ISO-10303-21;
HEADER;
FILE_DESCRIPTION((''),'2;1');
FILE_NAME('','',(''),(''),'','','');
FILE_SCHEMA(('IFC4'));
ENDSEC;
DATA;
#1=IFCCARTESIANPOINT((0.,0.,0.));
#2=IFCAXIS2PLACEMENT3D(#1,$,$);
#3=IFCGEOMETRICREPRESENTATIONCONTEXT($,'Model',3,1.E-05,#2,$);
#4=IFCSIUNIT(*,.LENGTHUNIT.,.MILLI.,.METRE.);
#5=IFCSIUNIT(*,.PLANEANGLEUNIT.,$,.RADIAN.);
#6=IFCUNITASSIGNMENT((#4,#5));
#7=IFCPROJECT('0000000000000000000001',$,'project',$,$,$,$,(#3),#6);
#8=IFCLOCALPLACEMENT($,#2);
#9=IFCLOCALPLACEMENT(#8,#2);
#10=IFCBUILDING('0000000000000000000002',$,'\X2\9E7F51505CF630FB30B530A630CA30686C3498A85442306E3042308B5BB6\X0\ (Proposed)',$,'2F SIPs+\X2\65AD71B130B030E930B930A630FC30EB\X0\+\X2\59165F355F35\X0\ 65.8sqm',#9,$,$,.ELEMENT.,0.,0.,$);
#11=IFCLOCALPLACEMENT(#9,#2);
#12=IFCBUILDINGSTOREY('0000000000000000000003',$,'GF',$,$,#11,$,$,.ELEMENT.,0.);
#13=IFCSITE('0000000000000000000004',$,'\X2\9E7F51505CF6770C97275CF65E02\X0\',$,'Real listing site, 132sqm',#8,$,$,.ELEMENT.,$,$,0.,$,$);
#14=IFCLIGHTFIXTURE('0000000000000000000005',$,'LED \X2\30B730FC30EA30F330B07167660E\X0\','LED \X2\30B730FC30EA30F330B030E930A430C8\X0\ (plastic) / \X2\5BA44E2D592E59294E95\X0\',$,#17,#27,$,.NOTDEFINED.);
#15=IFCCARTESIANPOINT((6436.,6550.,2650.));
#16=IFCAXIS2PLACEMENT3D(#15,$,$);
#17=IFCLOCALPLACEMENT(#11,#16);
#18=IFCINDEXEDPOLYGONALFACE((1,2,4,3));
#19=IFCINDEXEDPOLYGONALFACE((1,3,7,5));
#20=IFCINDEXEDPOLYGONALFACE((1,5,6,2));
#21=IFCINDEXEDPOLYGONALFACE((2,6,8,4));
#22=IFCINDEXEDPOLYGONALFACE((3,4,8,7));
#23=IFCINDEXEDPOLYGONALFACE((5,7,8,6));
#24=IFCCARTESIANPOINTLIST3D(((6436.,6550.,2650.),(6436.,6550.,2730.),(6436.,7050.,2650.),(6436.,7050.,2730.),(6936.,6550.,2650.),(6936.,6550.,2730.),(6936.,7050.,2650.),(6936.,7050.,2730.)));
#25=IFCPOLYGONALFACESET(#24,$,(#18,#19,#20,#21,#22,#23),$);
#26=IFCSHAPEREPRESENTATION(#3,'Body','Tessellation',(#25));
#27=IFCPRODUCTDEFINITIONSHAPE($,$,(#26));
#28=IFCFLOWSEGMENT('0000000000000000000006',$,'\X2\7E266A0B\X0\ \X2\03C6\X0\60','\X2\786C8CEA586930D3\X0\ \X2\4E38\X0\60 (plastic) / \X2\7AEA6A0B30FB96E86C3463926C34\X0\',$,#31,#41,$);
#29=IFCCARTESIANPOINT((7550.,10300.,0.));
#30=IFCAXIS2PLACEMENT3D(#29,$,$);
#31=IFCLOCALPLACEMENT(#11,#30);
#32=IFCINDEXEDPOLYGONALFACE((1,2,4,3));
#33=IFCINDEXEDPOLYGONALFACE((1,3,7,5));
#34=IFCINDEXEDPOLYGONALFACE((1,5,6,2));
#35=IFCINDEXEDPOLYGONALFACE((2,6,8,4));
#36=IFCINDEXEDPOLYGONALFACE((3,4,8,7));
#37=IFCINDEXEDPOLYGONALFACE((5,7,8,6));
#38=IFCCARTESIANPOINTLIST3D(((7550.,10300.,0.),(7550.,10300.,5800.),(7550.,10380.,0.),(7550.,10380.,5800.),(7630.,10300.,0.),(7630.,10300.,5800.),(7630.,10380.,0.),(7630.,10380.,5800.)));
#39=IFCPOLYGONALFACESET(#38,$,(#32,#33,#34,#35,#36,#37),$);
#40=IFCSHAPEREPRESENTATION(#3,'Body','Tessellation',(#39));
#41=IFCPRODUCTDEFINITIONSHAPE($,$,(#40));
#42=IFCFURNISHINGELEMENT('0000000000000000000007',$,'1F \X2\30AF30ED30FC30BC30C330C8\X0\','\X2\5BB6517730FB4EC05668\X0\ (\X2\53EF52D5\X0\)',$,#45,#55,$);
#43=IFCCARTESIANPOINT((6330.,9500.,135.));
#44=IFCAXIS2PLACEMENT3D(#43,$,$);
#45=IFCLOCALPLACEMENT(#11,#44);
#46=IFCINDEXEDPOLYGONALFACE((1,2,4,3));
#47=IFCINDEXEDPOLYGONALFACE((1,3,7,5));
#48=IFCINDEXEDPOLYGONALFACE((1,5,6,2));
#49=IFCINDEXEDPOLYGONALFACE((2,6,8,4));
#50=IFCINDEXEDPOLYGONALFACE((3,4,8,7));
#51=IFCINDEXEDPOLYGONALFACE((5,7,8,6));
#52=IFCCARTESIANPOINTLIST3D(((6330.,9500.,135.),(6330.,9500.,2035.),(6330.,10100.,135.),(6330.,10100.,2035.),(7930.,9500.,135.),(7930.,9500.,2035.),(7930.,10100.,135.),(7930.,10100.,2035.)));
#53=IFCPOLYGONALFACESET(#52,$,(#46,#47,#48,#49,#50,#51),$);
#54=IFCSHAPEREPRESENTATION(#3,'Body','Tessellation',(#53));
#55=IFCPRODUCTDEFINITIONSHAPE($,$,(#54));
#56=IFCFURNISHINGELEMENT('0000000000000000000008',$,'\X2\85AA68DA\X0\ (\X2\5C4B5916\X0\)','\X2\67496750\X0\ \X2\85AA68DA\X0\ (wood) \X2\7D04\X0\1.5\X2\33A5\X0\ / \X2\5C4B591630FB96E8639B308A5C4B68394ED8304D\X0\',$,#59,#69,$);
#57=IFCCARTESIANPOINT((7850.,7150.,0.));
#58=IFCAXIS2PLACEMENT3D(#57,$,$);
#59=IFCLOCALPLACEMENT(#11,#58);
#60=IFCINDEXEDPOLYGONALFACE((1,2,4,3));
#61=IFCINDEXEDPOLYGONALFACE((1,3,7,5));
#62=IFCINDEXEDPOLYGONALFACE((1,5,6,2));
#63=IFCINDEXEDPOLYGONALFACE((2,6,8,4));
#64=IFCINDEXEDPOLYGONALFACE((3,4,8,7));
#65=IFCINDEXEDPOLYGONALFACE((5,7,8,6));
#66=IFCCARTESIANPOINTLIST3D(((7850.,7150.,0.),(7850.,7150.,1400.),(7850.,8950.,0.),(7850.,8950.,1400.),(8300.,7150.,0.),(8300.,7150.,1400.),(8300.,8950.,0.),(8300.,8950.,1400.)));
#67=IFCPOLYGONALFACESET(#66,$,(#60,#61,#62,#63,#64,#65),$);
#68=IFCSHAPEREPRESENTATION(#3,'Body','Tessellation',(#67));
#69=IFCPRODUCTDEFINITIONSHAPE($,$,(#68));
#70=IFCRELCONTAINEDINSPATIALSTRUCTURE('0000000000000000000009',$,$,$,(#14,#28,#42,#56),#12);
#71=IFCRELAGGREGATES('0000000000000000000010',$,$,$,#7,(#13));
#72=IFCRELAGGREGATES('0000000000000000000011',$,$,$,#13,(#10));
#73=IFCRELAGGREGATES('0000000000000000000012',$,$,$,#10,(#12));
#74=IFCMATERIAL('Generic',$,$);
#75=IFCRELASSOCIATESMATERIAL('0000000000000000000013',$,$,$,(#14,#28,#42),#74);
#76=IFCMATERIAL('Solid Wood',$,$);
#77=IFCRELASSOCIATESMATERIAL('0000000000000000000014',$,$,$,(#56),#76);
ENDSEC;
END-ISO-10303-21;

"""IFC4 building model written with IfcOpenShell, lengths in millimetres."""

from ifc_helpers import new_model, si_unit, frame, frame_2d, origin, place, context, project, spatial, rectangle, extrude, material, element, save


model = new_model("IFC4")

# Units and contexts
model_context = context("Model", 3, precision=1e-05, world=origin())
ifc_project = project(units=[si_unit("LENGTHUNIT", "METRE", prefix="MILLI"), si_unit("PLANEANGLEUNIT", "RADIAN")], contexts=[model_context])

# Site, building, storey
site_placement = place(None, origin())
site = spatial("IfcSite", under=ifc_project, at=site_placement, Name="鹿児島県霧島市", ObjectType="Real listing site, 132sqm", CompositionType="ELEMENT", RefElevation=0.0)
building_placement = place(site_placement, origin())
building = spatial("IfcBuilding", under=site, at=building_placement, Name="鹿児島・サウナと水風呂のある家 (Proposed)", ObjectType="2F SIPs+断熱グラスウール+外張張 65.8sqm", CompositionType="ELEMENT", ElevationOfRefHeight=0.0, ElevationOfTerrain=0.0)
storey_placement = place(building_placement, origin())
storey = spatial("IfcBuildingStorey", under=building, at=storey_placement, Name="GF", CompositionType="ELEMENT", Elevation=0.0)

# Shared definitions
ifc_material_1 = material(Name="Solid Wood")

# Shared definitions
ifc_material_2 = material(Name="Generic")

# Light fixture
light_fixture_placement = place(storey_placement, frame((6436.0, 6550.0, 2650.0)))
element("IfcLightFixture", 1, at=light_fixture_placement, inside=storey, material=ifc_material_2, Name="LED シーリング照明", Description="LED シーリングライト (plastic) / 室中央天井", PredefinedType="NOTDEFINED", context=model_context, shape_type="SweptSolid", body=[
    extrude(rectangle(XDim=500.0, YDim=500.0, at=frame_2d((250.0, 250.0))), frame((6436.0, 6550.0, 2650.0)), (0.0, 0.0, 1.0), 80.0),
])

# Flow segment
flow_segment_placement = place(storey_placement, frame((7550.0, 10300.0, 0.0)))
element("IfcFlowSegment", 2, at=flow_segment_placement, inside=storey, material=ifc_material_2, Name="縦樋 φ60", Description="硬質塩ビ 丸60 (plastic) / 竪樋・雨水排水", context=model_context, shape_type="SweptSolid", body=[
    extrude(rectangle(XDim=80.0, YDim=80.0, at=frame_2d((40.0, 40.0))), frame((7550.0, 10300.0, 0.0)), (0.0, 0.0, 1.0), 5800.0),
])

# Furnishing elements
furnishing_1_placement = place(storey_placement, frame((6330.0, 9500.0, 135.0)))
element("IfcFurnishingElement", 3, at=furnishing_1_placement, inside=storey, material=ifc_material_2, Name="1F クローゼット", Description="家具・什器 (可動)", context=model_context, shape_type="SweptSolid", body=[
    extrude(rectangle(XDim=1600.0, YDim=600.0, at=frame_2d((800.0, 300.0))), frame((6330.0, 9500.0, 135.0)), (0.0, 0.0, 1.0), 1900.0),
])
furnishing_2_placement = place(storey_placement, frame((7850.0, 7150.0, 0.0)))
element("IfcFurnishingElement", 4, at=furnishing_2_placement, inside=storey, material=ifc_material_1, Name="薪棚 (屋外)", Description="杉材 薪棚 (wood) 約1.5㎥ / 屋外・雨掛り屋根付き", context=model_context, shape_type="SweptSolid", body=[
    extrude(rectangle(XDim=450.0, YDim=1800.0, at=frame_2d((225.0, 900.0))), frame((7850.0, 7150.0, 0.0)), (0.0, 0.0, 1.0), 1400.0),
])

save(model, "model.ifc")
